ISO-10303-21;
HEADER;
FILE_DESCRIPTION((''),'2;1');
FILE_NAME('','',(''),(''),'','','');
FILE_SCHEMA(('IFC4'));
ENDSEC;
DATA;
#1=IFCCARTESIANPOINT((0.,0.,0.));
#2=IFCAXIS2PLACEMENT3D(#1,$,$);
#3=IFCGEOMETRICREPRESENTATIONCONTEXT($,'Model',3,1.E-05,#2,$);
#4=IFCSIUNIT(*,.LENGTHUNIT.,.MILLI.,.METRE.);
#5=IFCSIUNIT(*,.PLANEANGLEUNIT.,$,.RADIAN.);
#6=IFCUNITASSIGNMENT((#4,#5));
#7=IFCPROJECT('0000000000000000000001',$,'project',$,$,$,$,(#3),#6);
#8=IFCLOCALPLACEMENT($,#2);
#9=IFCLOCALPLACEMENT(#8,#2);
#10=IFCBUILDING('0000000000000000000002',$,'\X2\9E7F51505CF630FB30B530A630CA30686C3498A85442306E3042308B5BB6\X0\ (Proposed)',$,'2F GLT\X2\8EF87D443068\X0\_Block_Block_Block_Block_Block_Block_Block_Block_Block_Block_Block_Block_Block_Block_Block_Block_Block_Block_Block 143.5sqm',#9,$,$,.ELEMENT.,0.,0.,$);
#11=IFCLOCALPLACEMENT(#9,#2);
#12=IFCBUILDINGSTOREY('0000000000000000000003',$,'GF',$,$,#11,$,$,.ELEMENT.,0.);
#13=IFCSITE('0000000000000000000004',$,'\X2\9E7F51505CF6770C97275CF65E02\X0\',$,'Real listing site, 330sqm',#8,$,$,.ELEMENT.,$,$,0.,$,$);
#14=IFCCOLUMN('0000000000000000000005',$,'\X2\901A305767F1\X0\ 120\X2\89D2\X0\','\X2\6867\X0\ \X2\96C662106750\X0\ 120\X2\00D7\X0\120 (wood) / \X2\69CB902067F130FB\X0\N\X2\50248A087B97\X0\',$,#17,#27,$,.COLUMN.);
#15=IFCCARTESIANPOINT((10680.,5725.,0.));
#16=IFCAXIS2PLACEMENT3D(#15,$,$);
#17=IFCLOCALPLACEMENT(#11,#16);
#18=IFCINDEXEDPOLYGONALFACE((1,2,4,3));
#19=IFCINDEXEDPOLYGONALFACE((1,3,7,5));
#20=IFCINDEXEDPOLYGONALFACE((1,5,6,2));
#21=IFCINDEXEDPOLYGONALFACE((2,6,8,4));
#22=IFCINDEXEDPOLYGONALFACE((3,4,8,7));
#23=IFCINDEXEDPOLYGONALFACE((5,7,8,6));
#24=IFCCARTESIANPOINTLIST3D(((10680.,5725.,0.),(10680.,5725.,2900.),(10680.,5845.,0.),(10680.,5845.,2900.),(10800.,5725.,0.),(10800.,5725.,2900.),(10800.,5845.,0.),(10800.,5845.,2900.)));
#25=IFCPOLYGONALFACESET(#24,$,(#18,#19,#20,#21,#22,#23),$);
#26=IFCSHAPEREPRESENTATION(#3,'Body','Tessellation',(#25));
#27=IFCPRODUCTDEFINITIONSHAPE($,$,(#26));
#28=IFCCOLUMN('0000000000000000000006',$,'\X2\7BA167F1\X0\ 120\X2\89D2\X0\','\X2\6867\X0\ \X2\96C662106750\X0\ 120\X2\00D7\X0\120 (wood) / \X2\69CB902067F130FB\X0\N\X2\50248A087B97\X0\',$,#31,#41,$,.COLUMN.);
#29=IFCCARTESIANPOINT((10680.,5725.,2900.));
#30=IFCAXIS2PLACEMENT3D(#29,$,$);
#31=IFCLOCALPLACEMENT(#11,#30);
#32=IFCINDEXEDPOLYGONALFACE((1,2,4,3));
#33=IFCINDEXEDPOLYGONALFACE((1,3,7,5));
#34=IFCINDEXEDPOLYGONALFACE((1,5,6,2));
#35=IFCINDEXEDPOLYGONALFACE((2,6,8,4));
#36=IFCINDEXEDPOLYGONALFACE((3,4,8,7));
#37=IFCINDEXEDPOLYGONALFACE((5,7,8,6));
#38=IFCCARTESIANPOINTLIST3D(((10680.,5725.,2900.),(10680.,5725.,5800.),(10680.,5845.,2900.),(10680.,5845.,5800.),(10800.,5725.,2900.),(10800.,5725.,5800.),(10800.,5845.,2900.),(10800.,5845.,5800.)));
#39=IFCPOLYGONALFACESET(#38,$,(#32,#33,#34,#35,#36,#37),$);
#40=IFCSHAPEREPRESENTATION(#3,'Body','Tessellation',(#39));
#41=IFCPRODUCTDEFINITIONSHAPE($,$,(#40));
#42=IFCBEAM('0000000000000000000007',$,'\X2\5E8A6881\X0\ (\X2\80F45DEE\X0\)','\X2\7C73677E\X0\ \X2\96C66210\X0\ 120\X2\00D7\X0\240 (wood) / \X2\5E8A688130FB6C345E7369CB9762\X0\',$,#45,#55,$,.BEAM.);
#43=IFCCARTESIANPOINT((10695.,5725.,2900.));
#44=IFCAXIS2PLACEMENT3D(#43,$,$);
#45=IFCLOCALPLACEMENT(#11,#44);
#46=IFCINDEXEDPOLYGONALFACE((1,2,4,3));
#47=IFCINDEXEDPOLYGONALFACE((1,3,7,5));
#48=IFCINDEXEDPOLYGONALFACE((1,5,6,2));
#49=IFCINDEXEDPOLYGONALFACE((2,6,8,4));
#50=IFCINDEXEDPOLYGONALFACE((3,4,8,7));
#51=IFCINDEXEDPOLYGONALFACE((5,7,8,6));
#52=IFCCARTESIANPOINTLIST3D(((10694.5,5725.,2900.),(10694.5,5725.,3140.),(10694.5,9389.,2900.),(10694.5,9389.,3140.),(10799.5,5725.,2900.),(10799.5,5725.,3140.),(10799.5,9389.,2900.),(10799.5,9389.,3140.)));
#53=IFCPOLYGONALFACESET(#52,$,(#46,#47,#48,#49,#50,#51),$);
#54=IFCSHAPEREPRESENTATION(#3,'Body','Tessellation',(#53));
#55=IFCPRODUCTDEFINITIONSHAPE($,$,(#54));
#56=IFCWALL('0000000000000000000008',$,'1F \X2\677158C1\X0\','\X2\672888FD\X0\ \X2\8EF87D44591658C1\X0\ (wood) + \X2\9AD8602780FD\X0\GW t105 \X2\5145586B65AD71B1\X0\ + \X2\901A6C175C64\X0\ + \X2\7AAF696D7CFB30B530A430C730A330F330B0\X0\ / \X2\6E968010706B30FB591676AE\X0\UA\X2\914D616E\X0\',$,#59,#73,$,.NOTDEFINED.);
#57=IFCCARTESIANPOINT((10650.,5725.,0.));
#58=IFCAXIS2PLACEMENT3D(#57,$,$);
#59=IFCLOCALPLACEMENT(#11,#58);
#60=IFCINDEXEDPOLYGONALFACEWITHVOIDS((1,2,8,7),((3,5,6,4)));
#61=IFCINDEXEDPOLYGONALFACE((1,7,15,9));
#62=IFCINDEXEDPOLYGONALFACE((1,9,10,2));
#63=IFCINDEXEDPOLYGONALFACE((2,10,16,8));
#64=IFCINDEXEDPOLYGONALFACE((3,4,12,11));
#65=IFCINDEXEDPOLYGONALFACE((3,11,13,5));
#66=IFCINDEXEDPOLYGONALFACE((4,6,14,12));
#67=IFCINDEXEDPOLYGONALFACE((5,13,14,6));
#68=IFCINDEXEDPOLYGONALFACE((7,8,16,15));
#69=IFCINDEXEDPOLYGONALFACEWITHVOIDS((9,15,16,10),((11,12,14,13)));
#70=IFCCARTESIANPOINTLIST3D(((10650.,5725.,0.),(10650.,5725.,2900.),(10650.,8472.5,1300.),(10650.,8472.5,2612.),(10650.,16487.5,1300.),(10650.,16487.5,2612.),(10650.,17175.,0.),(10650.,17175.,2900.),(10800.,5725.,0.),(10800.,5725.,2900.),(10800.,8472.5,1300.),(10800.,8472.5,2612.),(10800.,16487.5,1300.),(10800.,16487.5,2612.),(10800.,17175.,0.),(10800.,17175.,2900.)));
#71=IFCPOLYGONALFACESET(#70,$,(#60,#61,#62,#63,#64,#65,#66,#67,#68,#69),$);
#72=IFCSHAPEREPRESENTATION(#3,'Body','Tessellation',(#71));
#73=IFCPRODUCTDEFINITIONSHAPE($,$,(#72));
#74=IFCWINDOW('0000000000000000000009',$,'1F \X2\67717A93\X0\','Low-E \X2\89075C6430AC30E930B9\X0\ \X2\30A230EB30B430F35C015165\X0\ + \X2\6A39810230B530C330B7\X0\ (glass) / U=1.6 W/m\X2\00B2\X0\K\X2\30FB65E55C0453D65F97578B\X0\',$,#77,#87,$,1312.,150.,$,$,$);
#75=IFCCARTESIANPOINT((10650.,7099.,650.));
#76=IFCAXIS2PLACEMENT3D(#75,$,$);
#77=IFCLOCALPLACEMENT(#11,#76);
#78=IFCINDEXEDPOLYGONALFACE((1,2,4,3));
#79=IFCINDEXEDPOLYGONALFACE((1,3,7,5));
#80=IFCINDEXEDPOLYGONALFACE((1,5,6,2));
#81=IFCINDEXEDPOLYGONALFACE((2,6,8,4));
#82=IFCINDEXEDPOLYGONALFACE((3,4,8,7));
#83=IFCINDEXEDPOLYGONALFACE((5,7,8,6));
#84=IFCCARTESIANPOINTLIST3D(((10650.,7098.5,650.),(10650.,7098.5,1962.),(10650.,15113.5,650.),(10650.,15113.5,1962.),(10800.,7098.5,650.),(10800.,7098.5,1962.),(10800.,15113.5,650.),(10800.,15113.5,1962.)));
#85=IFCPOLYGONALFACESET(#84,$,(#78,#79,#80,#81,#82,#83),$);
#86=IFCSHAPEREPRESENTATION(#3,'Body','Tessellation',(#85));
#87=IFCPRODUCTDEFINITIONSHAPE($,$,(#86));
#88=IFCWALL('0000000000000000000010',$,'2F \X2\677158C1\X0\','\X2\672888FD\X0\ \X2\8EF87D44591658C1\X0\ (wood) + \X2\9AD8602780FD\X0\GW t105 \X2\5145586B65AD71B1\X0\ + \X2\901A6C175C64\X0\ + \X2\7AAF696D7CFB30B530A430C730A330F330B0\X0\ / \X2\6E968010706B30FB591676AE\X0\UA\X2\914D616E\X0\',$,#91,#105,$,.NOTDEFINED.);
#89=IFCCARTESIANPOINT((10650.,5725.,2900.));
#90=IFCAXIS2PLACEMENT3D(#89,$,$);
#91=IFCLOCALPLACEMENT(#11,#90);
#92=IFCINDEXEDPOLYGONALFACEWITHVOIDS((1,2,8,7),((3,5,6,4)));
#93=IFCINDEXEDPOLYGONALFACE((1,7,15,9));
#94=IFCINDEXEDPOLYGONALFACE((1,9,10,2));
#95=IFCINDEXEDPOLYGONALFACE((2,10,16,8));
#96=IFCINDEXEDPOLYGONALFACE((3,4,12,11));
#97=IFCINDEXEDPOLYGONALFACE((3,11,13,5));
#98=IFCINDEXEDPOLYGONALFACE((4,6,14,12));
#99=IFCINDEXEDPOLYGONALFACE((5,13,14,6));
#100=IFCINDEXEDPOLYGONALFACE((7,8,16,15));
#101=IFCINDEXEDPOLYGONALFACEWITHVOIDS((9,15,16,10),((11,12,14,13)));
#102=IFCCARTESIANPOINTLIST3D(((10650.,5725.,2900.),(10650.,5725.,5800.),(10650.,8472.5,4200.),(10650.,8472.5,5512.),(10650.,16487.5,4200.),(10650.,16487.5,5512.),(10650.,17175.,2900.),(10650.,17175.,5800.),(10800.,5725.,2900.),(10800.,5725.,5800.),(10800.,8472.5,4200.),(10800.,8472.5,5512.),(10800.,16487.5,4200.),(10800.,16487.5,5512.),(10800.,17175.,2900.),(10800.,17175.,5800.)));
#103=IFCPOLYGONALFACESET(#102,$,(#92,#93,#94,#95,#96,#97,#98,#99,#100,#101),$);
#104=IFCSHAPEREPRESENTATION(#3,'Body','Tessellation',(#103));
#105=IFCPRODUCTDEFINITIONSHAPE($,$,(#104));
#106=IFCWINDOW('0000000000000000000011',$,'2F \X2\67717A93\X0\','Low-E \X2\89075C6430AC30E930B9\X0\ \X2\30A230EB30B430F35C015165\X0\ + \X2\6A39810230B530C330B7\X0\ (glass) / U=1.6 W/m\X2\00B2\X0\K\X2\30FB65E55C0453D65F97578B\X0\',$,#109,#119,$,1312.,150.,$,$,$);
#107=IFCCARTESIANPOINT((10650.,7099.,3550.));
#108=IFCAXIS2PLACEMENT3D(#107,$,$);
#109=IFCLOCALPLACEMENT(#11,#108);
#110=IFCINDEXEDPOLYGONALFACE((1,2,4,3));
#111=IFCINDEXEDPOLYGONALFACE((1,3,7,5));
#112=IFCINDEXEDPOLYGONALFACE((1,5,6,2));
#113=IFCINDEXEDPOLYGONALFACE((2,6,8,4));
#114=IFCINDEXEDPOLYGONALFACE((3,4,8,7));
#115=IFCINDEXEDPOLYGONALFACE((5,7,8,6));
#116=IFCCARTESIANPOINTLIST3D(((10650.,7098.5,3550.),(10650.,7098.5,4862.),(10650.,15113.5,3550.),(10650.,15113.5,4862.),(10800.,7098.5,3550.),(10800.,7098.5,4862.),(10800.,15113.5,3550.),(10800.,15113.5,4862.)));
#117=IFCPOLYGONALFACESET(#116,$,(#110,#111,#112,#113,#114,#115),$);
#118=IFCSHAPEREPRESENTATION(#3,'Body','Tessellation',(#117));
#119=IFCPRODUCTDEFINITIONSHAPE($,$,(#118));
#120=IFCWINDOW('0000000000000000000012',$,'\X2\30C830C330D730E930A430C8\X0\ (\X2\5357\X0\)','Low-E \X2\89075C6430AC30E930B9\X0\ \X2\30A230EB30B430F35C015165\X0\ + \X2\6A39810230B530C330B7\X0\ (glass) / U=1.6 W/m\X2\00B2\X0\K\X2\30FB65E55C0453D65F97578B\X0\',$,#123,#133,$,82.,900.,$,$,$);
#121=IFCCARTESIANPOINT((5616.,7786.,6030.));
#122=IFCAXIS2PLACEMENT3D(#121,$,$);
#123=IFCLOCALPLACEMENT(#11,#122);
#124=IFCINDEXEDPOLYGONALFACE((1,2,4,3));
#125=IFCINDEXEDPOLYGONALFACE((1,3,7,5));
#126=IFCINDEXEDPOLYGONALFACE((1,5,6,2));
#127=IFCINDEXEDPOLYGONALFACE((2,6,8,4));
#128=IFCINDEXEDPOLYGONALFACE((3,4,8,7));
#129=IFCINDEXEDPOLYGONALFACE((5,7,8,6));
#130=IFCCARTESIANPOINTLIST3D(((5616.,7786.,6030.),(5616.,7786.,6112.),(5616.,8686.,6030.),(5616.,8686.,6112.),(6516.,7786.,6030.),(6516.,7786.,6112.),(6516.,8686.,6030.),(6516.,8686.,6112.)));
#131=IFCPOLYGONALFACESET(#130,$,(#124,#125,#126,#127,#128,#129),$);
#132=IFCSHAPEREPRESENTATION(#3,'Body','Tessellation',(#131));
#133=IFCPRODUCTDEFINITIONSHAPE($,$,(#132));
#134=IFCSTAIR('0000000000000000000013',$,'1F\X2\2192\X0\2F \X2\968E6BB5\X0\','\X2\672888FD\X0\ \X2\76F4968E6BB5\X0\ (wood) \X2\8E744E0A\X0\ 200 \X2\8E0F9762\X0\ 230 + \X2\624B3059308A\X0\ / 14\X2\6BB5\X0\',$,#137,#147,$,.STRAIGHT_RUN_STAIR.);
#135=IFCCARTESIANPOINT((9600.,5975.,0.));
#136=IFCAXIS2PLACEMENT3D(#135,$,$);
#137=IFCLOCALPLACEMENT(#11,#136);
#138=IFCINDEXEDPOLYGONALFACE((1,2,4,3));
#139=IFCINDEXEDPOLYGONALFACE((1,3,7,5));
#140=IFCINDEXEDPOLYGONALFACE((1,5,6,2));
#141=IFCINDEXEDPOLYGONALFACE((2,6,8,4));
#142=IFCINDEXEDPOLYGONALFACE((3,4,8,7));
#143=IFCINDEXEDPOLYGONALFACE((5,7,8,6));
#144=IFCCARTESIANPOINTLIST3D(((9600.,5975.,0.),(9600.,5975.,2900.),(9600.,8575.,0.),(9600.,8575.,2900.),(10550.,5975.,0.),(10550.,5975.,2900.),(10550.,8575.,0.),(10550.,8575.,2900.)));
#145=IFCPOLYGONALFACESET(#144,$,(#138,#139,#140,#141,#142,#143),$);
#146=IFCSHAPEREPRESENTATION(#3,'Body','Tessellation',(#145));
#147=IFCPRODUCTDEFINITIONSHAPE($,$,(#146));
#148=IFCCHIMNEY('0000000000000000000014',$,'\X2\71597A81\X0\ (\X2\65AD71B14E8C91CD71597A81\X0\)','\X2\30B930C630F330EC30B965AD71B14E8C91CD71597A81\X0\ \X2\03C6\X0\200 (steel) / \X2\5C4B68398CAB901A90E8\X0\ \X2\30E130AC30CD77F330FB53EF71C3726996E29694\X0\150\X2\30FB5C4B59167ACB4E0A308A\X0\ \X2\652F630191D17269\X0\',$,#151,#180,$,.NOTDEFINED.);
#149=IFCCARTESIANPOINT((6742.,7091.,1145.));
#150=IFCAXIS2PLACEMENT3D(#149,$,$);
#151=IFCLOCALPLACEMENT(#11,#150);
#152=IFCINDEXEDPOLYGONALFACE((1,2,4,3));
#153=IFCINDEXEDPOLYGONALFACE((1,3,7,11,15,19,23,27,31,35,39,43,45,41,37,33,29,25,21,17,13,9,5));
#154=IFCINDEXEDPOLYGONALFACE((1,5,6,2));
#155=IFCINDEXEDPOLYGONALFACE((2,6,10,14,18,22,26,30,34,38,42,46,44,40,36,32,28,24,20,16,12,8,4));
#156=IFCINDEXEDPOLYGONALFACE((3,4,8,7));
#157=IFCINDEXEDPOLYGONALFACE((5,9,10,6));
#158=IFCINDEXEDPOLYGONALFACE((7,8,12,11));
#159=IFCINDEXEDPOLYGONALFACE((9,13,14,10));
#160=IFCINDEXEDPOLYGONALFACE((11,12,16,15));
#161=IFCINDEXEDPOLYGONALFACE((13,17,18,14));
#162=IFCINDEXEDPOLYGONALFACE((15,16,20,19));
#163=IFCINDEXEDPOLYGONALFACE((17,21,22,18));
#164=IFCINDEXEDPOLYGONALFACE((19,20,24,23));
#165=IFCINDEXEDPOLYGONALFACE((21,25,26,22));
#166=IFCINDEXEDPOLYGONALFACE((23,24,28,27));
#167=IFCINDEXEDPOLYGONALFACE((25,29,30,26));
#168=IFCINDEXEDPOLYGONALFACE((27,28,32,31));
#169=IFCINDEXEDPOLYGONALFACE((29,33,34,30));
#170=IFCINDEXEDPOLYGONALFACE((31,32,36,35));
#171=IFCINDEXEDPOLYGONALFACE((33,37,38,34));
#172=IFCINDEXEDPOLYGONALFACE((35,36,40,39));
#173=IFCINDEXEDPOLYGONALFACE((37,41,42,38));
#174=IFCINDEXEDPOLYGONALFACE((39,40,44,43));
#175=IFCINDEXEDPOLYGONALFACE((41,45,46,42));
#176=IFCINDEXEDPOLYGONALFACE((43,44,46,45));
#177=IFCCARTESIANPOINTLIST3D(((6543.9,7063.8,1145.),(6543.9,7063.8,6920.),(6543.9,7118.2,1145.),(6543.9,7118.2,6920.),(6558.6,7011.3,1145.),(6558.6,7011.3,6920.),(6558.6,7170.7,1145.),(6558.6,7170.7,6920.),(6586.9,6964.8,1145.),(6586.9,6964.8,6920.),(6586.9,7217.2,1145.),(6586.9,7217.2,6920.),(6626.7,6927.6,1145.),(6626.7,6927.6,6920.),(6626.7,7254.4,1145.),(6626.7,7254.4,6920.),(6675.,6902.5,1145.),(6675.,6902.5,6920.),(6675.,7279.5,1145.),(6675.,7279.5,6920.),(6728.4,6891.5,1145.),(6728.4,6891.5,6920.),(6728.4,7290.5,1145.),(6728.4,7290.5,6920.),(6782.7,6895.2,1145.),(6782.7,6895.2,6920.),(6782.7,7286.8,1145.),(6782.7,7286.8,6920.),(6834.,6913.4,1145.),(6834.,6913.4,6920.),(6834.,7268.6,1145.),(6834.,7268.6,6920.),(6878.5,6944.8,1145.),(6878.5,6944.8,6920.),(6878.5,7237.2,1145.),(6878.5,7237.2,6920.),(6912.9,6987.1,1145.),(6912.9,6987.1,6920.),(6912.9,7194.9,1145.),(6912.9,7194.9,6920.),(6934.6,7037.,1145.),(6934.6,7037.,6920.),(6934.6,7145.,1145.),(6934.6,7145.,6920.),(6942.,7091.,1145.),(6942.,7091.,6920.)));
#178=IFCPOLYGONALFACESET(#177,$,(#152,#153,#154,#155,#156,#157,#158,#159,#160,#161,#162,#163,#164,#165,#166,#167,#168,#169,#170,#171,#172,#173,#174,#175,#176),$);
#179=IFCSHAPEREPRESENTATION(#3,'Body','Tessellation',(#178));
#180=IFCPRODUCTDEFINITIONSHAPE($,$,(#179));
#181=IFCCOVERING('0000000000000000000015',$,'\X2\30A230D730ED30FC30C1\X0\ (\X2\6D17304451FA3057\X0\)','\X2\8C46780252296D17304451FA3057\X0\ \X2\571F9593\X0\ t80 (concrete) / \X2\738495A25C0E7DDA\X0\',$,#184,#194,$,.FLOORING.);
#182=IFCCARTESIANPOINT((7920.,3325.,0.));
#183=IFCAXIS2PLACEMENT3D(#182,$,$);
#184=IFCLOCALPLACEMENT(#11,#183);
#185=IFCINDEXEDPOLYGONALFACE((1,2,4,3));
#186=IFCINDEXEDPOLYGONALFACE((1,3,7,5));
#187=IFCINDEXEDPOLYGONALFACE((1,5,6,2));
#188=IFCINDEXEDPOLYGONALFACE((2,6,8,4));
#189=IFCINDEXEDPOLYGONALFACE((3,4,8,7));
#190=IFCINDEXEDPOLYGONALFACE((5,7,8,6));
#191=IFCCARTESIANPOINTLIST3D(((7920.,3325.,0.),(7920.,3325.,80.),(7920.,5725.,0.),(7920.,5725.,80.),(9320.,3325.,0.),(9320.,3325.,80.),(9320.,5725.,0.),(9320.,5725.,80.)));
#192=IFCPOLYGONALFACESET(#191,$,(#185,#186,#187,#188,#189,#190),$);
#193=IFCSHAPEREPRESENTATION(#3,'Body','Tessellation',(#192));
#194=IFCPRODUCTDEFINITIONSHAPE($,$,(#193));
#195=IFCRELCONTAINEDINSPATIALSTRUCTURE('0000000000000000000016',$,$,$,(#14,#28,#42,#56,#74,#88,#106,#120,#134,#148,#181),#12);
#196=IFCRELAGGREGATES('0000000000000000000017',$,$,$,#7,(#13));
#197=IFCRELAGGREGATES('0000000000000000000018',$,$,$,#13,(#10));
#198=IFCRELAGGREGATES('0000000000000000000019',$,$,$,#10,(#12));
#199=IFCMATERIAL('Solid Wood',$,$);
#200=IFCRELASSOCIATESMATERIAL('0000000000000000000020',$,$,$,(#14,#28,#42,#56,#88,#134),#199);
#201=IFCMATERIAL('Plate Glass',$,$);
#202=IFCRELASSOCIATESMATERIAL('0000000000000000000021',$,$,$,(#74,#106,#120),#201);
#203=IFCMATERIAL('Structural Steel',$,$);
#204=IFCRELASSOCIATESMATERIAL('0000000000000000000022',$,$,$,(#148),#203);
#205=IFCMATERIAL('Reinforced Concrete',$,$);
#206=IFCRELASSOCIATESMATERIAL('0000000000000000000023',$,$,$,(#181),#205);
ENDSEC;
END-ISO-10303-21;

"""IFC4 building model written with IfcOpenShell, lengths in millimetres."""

from ifc_helpers import new_model, si_unit, frame, frame_2d, origin, origin_2d, place, context, project, spatial, rectangle, circle, extrude, material, element, fill, save


model = new_model("IFC4")

# Units and contexts
model_context = context("Model", 3, precision=1e-05, world=origin())
ifc_project = project(units=[si_unit("LENGTHUNIT", "METRE", prefix="MILLI"), si_unit("PLANEANGLEUNIT", "RADIAN")], contexts=[model_context])

# Site, building, storey
site_placement = place(None, origin())
site = spatial("IfcSite", under=ifc_project, at=site_placement, Name="鹿児島県霧島市", ObjectType="Real listing site, 330sqm", CompositionType="ELEMENT", RefElevation=0.0)
building_placement = place(site_placement, origin())
building = spatial("IfcBuilding", under=site, at=building_placement, Name="鹿児島・サウナと水風呂のある家 (Proposed)", ObjectType="2F GLT軸組と_Block_Block_Block_Block_Block_Block_Block_Block_Block_Block_Block_Block_Block_Block_Block_Block_Block_Block_Block 143.5sqm", CompositionType="ELEMENT", ElevationOfRefHeight=0.0, ElevationOfTerrain=0.0)
storey_placement = place(building_placement, origin())
storey = spatial("IfcBuildingStorey", under=building, at=storey_placement, Name="GF", CompositionType="ELEMENT", Elevation=0.0)

# Columns
ifc_material_1 = material(Name="Solid Wood")
column_1_placement = place(storey_placement, frame((10680.0, 5725.0, 0.0)))
element("IfcColumn", 1, at=column_1_placement, inside=storey, material=ifc_material_1, Name="通し柱 120角", Description="桧 集成材 120×120 (wood) / 構造柱・N値計算", PredefinedType="COLUMN", context=model_context, shape_type="SweptSolid", body=[
    extrude(rectangle(XDim=120.0, YDim=120.0, at=frame_2d((60.0, 60.0))), frame((10680.0, 5725.0, 0.0)), (0.0, 0.0, 1.0), 2900.0),
])
column_2_placement = place(storey_placement, frame((10680.0, 5725.0, 2900.0)))
element("IfcColumn", 2, at=column_2_placement, inside=storey, material=ifc_material_1, Name="管柱 120角", Description="桧 集成材 120×120 (wood) / 構造柱・N値計算", PredefinedType="COLUMN", context=model_context, shape_type="SweptSolid", body=[
    extrude(rectangle(XDim=120.0, YDim=120.0, at=frame_2d((60.0, 60.0))), frame((10680.0, 5725.0, 2900.0)), (0.0, 0.0, 1.0), 2900.0),
])

# Beam
beam_1_placement = place(storey_placement, frame((10695.0, 5725.0, 2900.0)))
element("IfcBeam", 3, at=beam_1_placement, inside=storey, material=ifc_material_1, Name="床梁 (胴差)", Description="米松 集成 120×240 (wood) / 床梁・水平構面", PredefinedType="BEAM", context=model_context, shape_type="SweptSolid", body=[
    extrude(rectangle(XDim=105.0, YDim=3664.0, at=frame_2d((52.0, 1832.0))), frame((10695.0, 5725.0, 2900.0)), (0.0, 0.0, 1.0), 240.0),
])

# Wall, opening, window
wall_1_placement = place(storey_placement, frame((10650.0, 5725.0, 0.0)))
wall_1 = element("IfcWall", 4, at=wall_1_placement, inside=storey, material=ifc_material_1, Name="1F 東壁", Description="木製 軸組外壁 (wood) + 高性能GW t105 充填断熱 + 通気層 + 窯業系サイディング / 準耐火・外皮UA配慮", PredefinedType="NOTDEFINED", context=model_context, shape_type="SweptSolid", body=[
    extrude(rectangle(XDim=150.0, YDim=11450.0, at=frame_2d((75.0, 5725.0))), frame((10650.0, 5725.0, 0.0)), (0.0, 0.0, 1.0), 2900.0),
])
opening_1_placement = place(storey_placement, frame((10650.0, 7099.0, 650.0)))
opening_1 = element("IfcOpeningElement", 5, at=opening_1_placement, cuts=wall_1, PredefinedType="NOTDEFINED", context=model_context, shape_type="SweptSolid", body=[
    extrude(rectangle(XDim=150.0, YDim=8015.0, at=frame_2d((75.0, 4007.0))), frame((10650.0, 7099.0, 650.0)), (0.0, 0.0, 1.0), 1312.0),
])
ifc_material_2 = material(Name="Plate Glass")
window_1_placement = place(storey_placement, frame((10650.0, 7099.0, 650.0)))
window_1 = element("IfcWindow", 6, at=window_1_placement, inside=storey, material=ifc_material_2, Name="1F 東窓", Description="Low-E 複層ガラス アルゴン封入 + 樹脂サッシ (glass) / U=1.6 W/m²K・日射取得型", OverallHeight=1312.0, OverallWidth=150.0, context=model_context, shape_type="SweptSolid", body=[
    extrude(rectangle(XDim=150.0, YDim=8015.0, at=frame_2d((75.0, 4007.0))), frame((10650.0, 7099.0, 650.0)), (0.0, 0.0, 1.0), 1312.0),
])
fill(opening_1, window_1)

# Wall, opening, window
wall_2_placement = place(storey_placement, frame((10650.0, 5725.0, 2900.0)))
wall_2 = element("IfcWall", 7, at=wall_2_placement, inside=storey, material=ifc_material_1, Name="2F 東壁", Description="木製 軸組外壁 (wood) + 高性能GW t105 充填断熱 + 通気層 + 窯業系サイディング / 準耐火・外皮UA配慮", PredefinedType="NOTDEFINED", context=model_context, shape_type="SweptSolid", body=[
    extrude(rectangle(XDim=150.0, YDim=11450.0, at=frame_2d((75.0, 5725.0))), frame((10650.0, 5725.0, 2900.0)), (0.0, 0.0, 1.0), 2900.0),
])
opening_2_placement = place(storey_placement, frame((10650.0, 7099.0, 3550.0)))
opening_2 = element("IfcOpeningElement", 8, at=opening_2_placement, cuts=wall_2, PredefinedType="NOTDEFINED", context=model_context, shape_type="SweptSolid", body=[
    extrude(rectangle(XDim=150.0, YDim=8015.0, at=frame_2d((75.0, 4007.0))), frame((10650.0, 7099.0, 3550.0)), (0.0, 0.0, 1.0), 1312.0),
])
window_2_placement = place(storey_placement, frame((10650.0, 7099.0, 3550.0)))
window_2 = element("IfcWindow", 9, at=window_2_placement, inside=storey, material=ifc_material_2, Name="2F 東窓", Description="Low-E 複層ガラス アルゴン封入 + 樹脂サッシ (glass) / U=1.6 W/m²K・日射取得型", OverallHeight=1312.0, OverallWidth=150.0, context=model_context, shape_type="SweptSolid", body=[
    extrude(rectangle(XDim=150.0, YDim=8015.0, at=frame_2d((75.0, 4007.0))), frame((10650.0, 7099.0, 3550.0)), (0.0, 0.0, 1.0), 1312.0),
])
fill(opening_2, window_2)

# Window
window_3_placement = place(storey_placement, frame((5616.0, 7786.0, 6030.0)))
element("IfcWindow", 10, at=window_3_placement, inside=storey, material=ifc_material_2, Name="トップライト (南)", Description="Low-E 複層ガラス アルゴン封入 + 樹脂サッシ (glass) / U=1.6 W/m²K・日射取得型", OverallHeight=82.0, OverallWidth=900.0, context=model_context, shape_type="SweptSolid", body=[
    extrude(rectangle(XDim=900.0, YDim=900.0, at=frame_2d((450.0, 450.0))), frame((5616.0, 7786.0, 6030.0)), (0.0, 0.0, 1.0), 82.0),
])

# Stair
stair_placement = place(storey_placement, frame((9600.0, 5975.0, 0.0)))
element("IfcStair", 11, at=stair_placement, inside=storey, material=ifc_material_1, Name="1F→2F 階段", Description="木製 直階段 (wood) 蹴上 200 踏面 230 + 手すり / 14段", PredefinedType="STRAIGHT_RUN_STAIR", context=model_context, shape_type="SweptSolid", body=[
    extrude(rectangle(XDim=950.0, YDim=2600.0, at=frame_2d((475.0, 1300.0))), frame((9600.0, 5975.0, 0.0)), (0.0, 0.0, 1.0), 2900.0),
])

# Chimney
ifc_material_3 = material(Name="Structural Steel")
chimney_placement = place(storey_placement, frame((6742.0, 7091.0, 1145.0)))
element("IfcChimney", 12, at=chimney_placement, inside=storey, material=ifc_material_3, Name="煙突 (断熱二重煙突)", Description="ステンレス断熱二重煙突 φ200 (steel) / 屋根貫通部 メガネ石・可燃物離隔150・屋外立上り 支持金物", PredefinedType="NOTDEFINED", context=model_context, shape_type="SweptSolid", body=[
    extrude(circle(Radius=200.0, at=origin_2d()), frame((6742.0, 7091.0, 1145.0)), (0.0, 0.0, 1.0), 5775.0),
])

# Covering
ifc_material_4 = material(Name="Reinforced Concrete")
covering_1_placement = place(storey_placement, frame((7920.0, 3325.0, 0.0)))
element("IfcCovering", 13, at=covering_1_placement, inside=storey, material=ifc_material_4, Name="アプローチ (洗い出し)", Description="豆砂利洗い出し 土間 t80 (concrete) / 玄関導線", PredefinedType="FLOORING", context=model_context, shape_type="SweptSolid", body=[
    extrude(rectangle(XDim=1400.0, YDim=2400.0, at=frame_2d((700.0, 1200.0))), frame((7920.0, 3325.0, 0.0)), (0.0, 0.0, 1.0), 80.0),
])

save(model, "model.ifc")
